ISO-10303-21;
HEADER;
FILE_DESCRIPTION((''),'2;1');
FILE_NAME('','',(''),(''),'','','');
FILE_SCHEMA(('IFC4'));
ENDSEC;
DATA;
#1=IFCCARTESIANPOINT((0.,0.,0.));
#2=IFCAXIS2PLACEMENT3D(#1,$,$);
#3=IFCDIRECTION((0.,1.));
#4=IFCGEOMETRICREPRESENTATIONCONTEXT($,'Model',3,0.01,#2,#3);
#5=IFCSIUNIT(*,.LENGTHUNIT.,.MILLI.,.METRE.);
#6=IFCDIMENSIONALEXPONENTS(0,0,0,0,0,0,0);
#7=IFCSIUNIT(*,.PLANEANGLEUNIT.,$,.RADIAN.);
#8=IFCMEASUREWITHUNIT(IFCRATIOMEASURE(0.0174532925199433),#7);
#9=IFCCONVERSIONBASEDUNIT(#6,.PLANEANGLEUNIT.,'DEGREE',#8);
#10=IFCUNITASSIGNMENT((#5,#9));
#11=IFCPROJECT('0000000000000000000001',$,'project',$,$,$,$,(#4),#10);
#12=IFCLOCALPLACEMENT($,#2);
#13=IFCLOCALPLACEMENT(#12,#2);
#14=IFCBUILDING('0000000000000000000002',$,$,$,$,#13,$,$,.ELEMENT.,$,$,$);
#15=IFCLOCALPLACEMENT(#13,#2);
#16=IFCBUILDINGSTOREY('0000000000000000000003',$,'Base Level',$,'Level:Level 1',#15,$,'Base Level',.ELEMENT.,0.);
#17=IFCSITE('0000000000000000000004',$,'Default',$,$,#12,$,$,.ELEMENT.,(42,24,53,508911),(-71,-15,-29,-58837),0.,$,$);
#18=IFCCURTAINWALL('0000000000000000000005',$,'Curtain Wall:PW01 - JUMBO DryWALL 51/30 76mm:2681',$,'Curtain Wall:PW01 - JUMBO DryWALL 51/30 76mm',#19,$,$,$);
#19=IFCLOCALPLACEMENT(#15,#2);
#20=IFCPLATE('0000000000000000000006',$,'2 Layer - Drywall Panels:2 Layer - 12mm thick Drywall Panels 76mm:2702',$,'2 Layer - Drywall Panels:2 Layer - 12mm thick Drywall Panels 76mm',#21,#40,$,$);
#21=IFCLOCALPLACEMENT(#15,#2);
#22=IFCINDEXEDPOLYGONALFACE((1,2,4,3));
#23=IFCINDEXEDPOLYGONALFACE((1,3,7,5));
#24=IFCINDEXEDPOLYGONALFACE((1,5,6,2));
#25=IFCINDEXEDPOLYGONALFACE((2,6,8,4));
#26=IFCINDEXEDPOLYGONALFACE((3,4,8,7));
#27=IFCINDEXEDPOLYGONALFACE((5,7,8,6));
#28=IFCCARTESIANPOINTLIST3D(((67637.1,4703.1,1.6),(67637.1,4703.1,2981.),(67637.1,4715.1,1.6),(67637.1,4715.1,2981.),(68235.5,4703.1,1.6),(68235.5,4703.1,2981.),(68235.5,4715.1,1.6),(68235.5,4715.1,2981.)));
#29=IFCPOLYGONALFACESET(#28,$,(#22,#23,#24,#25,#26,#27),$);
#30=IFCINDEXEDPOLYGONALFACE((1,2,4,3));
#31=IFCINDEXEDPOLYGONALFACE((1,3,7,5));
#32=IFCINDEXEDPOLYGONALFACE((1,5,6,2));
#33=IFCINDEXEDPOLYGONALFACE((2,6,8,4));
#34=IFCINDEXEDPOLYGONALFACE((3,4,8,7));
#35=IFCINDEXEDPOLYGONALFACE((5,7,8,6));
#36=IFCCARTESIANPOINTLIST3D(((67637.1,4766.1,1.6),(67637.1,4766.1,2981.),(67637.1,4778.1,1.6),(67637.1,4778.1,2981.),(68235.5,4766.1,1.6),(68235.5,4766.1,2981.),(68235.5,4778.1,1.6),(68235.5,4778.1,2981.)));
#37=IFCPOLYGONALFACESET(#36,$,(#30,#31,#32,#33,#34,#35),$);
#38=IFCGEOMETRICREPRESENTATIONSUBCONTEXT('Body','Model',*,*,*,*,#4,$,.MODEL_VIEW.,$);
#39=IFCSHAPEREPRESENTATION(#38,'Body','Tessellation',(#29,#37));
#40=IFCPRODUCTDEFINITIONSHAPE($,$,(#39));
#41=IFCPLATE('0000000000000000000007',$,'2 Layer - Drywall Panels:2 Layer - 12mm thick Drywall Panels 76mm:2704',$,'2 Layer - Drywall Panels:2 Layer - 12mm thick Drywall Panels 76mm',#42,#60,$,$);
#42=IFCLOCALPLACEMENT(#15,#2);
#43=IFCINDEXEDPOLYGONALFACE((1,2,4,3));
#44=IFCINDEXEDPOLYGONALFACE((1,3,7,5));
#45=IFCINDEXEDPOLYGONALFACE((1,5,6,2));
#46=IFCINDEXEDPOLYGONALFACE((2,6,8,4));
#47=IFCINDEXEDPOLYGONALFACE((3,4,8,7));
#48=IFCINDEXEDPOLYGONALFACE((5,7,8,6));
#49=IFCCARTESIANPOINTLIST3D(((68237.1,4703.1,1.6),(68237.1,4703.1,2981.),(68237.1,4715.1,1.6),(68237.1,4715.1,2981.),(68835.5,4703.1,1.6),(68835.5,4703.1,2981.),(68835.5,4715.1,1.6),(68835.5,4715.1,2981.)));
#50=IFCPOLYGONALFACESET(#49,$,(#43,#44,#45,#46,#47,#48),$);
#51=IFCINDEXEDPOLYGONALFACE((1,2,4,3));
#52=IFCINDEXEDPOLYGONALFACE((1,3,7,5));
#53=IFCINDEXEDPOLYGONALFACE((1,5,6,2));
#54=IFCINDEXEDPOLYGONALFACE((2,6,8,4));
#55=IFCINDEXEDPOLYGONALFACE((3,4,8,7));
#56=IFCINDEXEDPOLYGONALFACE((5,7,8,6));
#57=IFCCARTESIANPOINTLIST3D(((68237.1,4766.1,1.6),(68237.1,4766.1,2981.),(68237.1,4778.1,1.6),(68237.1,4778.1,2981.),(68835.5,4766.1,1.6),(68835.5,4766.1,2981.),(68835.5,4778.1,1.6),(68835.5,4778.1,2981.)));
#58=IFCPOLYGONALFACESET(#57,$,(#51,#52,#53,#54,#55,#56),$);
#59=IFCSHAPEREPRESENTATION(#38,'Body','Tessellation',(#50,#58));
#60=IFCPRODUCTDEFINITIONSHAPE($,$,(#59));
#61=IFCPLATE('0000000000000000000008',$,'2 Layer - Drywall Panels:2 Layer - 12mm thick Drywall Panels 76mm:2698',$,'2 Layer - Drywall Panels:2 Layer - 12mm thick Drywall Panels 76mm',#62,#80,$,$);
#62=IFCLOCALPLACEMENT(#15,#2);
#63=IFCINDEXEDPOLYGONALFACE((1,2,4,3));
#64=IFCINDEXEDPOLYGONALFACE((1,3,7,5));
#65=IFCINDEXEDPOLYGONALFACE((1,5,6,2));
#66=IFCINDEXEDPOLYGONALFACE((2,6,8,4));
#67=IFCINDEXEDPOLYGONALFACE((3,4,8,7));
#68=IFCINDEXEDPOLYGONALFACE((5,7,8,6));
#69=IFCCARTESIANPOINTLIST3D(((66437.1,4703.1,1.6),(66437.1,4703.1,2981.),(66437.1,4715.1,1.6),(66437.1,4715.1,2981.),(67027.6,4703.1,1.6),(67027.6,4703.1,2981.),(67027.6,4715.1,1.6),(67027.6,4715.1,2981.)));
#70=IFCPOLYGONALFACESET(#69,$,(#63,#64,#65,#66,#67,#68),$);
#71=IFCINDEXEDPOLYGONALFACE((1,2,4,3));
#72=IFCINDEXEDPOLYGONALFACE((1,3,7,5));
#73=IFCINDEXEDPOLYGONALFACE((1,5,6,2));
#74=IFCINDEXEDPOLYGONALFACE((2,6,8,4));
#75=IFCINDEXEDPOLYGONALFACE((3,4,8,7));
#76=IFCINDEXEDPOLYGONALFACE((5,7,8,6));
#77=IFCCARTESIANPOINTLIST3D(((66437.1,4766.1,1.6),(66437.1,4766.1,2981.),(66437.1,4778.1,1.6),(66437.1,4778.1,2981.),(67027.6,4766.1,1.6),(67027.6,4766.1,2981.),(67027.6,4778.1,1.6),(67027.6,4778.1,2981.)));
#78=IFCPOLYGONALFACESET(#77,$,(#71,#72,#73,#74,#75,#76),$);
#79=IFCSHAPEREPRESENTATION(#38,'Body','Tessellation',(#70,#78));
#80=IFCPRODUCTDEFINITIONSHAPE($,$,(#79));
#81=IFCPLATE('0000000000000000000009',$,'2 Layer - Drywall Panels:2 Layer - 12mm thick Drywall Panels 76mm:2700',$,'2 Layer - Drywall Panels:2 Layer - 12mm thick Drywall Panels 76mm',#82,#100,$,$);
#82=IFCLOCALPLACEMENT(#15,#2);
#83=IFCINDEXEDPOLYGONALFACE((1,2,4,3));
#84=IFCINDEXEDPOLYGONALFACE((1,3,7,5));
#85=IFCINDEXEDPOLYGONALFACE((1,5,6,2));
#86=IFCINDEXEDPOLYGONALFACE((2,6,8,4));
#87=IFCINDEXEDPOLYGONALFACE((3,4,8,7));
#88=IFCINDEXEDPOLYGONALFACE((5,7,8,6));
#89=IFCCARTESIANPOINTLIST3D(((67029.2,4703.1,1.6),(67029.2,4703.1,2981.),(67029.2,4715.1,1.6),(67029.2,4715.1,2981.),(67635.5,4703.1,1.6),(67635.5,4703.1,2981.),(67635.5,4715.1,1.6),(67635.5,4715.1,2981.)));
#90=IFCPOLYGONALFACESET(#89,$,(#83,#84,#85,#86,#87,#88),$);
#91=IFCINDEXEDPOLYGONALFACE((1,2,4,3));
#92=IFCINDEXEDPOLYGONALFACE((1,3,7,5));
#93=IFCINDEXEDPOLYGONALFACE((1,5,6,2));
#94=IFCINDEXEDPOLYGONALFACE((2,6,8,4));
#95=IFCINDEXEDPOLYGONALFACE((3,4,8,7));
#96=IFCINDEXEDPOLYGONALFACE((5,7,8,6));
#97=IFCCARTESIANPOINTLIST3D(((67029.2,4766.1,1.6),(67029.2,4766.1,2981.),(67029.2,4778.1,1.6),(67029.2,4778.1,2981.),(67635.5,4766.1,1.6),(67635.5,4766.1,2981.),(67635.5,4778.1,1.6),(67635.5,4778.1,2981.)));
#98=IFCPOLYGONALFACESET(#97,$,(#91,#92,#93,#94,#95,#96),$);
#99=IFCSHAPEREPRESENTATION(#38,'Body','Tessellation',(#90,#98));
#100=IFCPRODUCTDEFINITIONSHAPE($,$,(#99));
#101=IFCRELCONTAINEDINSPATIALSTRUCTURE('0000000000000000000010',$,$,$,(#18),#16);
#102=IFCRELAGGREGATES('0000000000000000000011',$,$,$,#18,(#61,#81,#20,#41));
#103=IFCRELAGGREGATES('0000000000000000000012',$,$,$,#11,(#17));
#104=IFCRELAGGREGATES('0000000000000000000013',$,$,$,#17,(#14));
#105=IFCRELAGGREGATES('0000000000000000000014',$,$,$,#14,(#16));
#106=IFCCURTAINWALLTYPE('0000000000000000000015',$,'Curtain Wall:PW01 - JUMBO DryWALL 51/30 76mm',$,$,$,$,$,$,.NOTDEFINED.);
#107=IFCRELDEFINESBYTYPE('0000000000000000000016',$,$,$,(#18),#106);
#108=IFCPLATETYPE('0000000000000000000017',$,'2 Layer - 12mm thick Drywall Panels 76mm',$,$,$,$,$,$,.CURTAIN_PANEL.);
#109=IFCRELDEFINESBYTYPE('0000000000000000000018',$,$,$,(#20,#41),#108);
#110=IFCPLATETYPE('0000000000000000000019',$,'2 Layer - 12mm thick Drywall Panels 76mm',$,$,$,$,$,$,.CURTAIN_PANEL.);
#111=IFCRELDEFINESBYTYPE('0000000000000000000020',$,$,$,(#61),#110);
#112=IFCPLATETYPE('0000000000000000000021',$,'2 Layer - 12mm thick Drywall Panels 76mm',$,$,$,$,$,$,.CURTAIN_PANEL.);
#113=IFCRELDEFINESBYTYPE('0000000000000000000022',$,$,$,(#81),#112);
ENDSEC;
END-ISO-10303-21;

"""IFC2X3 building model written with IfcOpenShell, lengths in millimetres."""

from ifc_helpers import new_model, entity, si_unit, converted_unit, direction, frame, frame_2d, origin, origin_2d_with_axis, place, context, subcontext, project, spatial, rectangle, extrude, source, transform, mapped, type_object, type_shapes, element, aggregate, save


model = new_model("IFC2X3")

# Units and contexts
model_context = context("Model", 3, precision=0.01, world=origin(), true_north=direction((0.0, 1.0)))
body_context = subcontext(model_context, "Body", "Model", "MODEL_VIEW")
ifc_project = project(units=[si_unit("LENGTHUNIT", "METRE", prefix="MILLI"), converted_unit("PLANEANGLEUNIT", "DEGREE", entity("IfcRatioMeasure", 0.0174532925199433), si_unit("PLANEANGLEUNIT", "RADIAN"), dimensions=[0, 0, 0, 0, 0, 0, 0])], contexts=[model_context])

# Site, building, storey
site_placement = place(None, origin())
site = spatial("IfcSite", under=ifc_project, at=site_placement, Name="Default", CompositionType="ELEMENT", RefLatitude=(42, 24, 53, 508911), RefLongitude=(-71, -15, -29, -58837), RefElevation=0.0)
building_placement = place(site_placement, origin())
building = spatial("IfcBuilding", under=site, at=building_placement, CompositionType="ELEMENT")
storey_placement = place(building_placement, origin())
storey = spatial("IfcBuildingStorey", under=building, at=storey_placement, Name="Base Level", ObjectType="Level:Level 1", LongName="Base Level", CompositionType="ELEMENT", Elevation=0.0)

# Curtain wall, plates
curtain_wall_type = type_object("IfcCurtainWallType", Name="Curtain Wall:PW01 - JUMBO DryWALL 51/30 76mm", PredefinedType="NOTDEFINED")
curtain_wall_placement = place(building_placement, origin())
curtain_wall = element("IfcCurtainWall", 1, at=curtain_wall_placement, inside=storey, type_object=curtain_wall_type, Name="Curtain Wall:PW01 - JUMBO DryWALL 51/30 76mm:2681", ObjectType="Curtain Wall:PW01 - JUMBO DryWALL 51/30 76mm")
plate_type_1 = type_object("IfcPlateType", Name="2 Layer - 12mm thick Drywall Panels 76mm", PredefinedType="CURTAIN_PANEL")
shared_shape_1 = source(origin(), body_context, "Body", "SweptSolid", [
    extrude(rectangle(XDim=598.4, YDim=12.0, at=origin_2d_with_axis()), frame((0.0, -31.5, 0.0), z_axis=(0.0, 0.0, 1.0), x_axis=(-1.0, 0.0, 0.0)), (0.0, 0.0, 1.0), 2979.4),
    extrude(rectangle(XDim=12.0, YDim=598.4, at=frame_2d((0.0, 0.0), x_axis=(1.0, 0.0))), frame((0.0, 31.5, 0.0), z_axis=(0.0, 0.0, 1.0), x_axis=(0.0, 1.0, 0.0)), (0.0, 0.0, 1.0), 2979.4),
])
type_shapes(plate_type_1, [shared_shape_1])
plate_1_placement = place(curtain_wall_placement, frame((67936.3, 4740.6, 1.6)))
plate_1 = element("IfcPlate", 2, at=plate_1_placement, type_object=plate_type_1, Name="2 Layer - Drywall Panels:2 Layer - 12mm thick Drywall Panels 76mm:2702", ObjectType="2 Layer - Drywall Panels:2 Layer - 12mm thick Drywall Panels 76mm", context=body_context, shape_type="MappedRepresentation", body=[
    mapped(shared_shape_1, transform((0.0, 0.0, 0.0), scale=1.0)),
])
plate_2_placement = place(curtain_wall_placement, frame((68536.3, 4740.6, 1.6)))
plate_2 = element("IfcPlate", 3, at=plate_2_placement, type_object=plate_type_1, Name="2 Layer - Drywall Panels:2 Layer - 12mm thick Drywall Panels 76mm:2704", ObjectType="2 Layer - Drywall Panels:2 Layer - 12mm thick Drywall Panels 76mm", context=body_context, shape_type="MappedRepresentation", body=[
    mapped(shared_shape_1, transform((0.0, 0.0, 0.0), scale=1.0)),
])
plate_type_2 = type_object("IfcPlateType", Name="2 Layer - 12mm thick Drywall Panels 76mm", PredefinedType="CURTAIN_PANEL")
shared_shape_2 = source(origin(), body_context, "Body", "SweptSolid", [
    extrude(rectangle(XDim=590.5, YDim=12.0, at=origin_2d_with_axis()), frame((0.0, -31.5, 0.0), z_axis=(0.0, 0.0, 1.0), x_axis=(-1.0, 0.0, 0.0)), (0.0, 0.0, 1.0), 2979.4),
    extrude(rectangle(XDim=12.0, YDim=590.5, at=frame_2d((0.0, 0.0), x_axis=(1.0, 0.0))), frame((0.0, 31.5, 0.0), z_axis=(0.0, 0.0, 1.0), x_axis=(0.0, 1.0, 0.0)), (0.0, 0.0, 1.0), 2979.4),
])
type_shapes(plate_type_2, [shared_shape_2])
plate_3_placement = place(curtain_wall_placement, frame((66732.4, 4740.6, 1.6)))
plate_3 = element("IfcPlate", 4, at=plate_3_placement, type_object=plate_type_2, Name="2 Layer - Drywall Panels:2 Layer - 12mm thick Drywall Panels 76mm:2698", ObjectType="2 Layer - Drywall Panels:2 Layer - 12mm thick Drywall Panels 76mm", context=body_context, shape_type="MappedRepresentation", body=[
    mapped(shared_shape_2, transform((0.0, 0.0, 0.0), scale=1.0)),
])
plate_type_3 = type_object("IfcPlateType", Name="2 Layer - 12mm thick Drywall Panels 76mm", PredefinedType="CURTAIN_PANEL")
shared_shape_3 = source(origin(), body_context, "Body", "SweptSolid", [
    extrude(rectangle(XDim=606.3, YDim=12.0, at=origin_2d_with_axis()), frame((0.0, -31.5, 0.0), z_axis=(0.0, 0.0, 1.0), x_axis=(-1.0, 0.0, 0.0)), (0.0, 0.0, 1.0), 2979.4),
    extrude(rectangle(XDim=12.0, YDim=606.3, at=frame_2d((0.0, 0.0), x_axis=(1.0, 0.0))), frame((0.0, 31.5, 0.0), z_axis=(0.0, 0.0, 1.0), x_axis=(0.0, 1.0, 0.0)), (0.0, 0.0, 1.0), 2979.4),
])
type_shapes(plate_type_3, [shared_shape_3])
plate_4_placement = place(curtain_wall_placement, frame((67332.4, 4740.6, 1.6)))
plate_4 = element("IfcPlate", 5, at=plate_4_placement, type_object=plate_type_3, Name="2 Layer - Drywall Panels:2 Layer - 12mm thick Drywall Panels 76mm:2700", ObjectType="2 Layer - Drywall Panels:2 Layer - 12mm thick Drywall Panels 76mm", context=body_context, shape_type="MappedRepresentation", body=[
    mapped(shared_shape_3, transform((0.0, 0.0, 0.0), scale=1.0)),
])
aggregate(curtain_wall, [plate_3, plate_4, plate_1, plate_2])

save(model, "model.ifc")
